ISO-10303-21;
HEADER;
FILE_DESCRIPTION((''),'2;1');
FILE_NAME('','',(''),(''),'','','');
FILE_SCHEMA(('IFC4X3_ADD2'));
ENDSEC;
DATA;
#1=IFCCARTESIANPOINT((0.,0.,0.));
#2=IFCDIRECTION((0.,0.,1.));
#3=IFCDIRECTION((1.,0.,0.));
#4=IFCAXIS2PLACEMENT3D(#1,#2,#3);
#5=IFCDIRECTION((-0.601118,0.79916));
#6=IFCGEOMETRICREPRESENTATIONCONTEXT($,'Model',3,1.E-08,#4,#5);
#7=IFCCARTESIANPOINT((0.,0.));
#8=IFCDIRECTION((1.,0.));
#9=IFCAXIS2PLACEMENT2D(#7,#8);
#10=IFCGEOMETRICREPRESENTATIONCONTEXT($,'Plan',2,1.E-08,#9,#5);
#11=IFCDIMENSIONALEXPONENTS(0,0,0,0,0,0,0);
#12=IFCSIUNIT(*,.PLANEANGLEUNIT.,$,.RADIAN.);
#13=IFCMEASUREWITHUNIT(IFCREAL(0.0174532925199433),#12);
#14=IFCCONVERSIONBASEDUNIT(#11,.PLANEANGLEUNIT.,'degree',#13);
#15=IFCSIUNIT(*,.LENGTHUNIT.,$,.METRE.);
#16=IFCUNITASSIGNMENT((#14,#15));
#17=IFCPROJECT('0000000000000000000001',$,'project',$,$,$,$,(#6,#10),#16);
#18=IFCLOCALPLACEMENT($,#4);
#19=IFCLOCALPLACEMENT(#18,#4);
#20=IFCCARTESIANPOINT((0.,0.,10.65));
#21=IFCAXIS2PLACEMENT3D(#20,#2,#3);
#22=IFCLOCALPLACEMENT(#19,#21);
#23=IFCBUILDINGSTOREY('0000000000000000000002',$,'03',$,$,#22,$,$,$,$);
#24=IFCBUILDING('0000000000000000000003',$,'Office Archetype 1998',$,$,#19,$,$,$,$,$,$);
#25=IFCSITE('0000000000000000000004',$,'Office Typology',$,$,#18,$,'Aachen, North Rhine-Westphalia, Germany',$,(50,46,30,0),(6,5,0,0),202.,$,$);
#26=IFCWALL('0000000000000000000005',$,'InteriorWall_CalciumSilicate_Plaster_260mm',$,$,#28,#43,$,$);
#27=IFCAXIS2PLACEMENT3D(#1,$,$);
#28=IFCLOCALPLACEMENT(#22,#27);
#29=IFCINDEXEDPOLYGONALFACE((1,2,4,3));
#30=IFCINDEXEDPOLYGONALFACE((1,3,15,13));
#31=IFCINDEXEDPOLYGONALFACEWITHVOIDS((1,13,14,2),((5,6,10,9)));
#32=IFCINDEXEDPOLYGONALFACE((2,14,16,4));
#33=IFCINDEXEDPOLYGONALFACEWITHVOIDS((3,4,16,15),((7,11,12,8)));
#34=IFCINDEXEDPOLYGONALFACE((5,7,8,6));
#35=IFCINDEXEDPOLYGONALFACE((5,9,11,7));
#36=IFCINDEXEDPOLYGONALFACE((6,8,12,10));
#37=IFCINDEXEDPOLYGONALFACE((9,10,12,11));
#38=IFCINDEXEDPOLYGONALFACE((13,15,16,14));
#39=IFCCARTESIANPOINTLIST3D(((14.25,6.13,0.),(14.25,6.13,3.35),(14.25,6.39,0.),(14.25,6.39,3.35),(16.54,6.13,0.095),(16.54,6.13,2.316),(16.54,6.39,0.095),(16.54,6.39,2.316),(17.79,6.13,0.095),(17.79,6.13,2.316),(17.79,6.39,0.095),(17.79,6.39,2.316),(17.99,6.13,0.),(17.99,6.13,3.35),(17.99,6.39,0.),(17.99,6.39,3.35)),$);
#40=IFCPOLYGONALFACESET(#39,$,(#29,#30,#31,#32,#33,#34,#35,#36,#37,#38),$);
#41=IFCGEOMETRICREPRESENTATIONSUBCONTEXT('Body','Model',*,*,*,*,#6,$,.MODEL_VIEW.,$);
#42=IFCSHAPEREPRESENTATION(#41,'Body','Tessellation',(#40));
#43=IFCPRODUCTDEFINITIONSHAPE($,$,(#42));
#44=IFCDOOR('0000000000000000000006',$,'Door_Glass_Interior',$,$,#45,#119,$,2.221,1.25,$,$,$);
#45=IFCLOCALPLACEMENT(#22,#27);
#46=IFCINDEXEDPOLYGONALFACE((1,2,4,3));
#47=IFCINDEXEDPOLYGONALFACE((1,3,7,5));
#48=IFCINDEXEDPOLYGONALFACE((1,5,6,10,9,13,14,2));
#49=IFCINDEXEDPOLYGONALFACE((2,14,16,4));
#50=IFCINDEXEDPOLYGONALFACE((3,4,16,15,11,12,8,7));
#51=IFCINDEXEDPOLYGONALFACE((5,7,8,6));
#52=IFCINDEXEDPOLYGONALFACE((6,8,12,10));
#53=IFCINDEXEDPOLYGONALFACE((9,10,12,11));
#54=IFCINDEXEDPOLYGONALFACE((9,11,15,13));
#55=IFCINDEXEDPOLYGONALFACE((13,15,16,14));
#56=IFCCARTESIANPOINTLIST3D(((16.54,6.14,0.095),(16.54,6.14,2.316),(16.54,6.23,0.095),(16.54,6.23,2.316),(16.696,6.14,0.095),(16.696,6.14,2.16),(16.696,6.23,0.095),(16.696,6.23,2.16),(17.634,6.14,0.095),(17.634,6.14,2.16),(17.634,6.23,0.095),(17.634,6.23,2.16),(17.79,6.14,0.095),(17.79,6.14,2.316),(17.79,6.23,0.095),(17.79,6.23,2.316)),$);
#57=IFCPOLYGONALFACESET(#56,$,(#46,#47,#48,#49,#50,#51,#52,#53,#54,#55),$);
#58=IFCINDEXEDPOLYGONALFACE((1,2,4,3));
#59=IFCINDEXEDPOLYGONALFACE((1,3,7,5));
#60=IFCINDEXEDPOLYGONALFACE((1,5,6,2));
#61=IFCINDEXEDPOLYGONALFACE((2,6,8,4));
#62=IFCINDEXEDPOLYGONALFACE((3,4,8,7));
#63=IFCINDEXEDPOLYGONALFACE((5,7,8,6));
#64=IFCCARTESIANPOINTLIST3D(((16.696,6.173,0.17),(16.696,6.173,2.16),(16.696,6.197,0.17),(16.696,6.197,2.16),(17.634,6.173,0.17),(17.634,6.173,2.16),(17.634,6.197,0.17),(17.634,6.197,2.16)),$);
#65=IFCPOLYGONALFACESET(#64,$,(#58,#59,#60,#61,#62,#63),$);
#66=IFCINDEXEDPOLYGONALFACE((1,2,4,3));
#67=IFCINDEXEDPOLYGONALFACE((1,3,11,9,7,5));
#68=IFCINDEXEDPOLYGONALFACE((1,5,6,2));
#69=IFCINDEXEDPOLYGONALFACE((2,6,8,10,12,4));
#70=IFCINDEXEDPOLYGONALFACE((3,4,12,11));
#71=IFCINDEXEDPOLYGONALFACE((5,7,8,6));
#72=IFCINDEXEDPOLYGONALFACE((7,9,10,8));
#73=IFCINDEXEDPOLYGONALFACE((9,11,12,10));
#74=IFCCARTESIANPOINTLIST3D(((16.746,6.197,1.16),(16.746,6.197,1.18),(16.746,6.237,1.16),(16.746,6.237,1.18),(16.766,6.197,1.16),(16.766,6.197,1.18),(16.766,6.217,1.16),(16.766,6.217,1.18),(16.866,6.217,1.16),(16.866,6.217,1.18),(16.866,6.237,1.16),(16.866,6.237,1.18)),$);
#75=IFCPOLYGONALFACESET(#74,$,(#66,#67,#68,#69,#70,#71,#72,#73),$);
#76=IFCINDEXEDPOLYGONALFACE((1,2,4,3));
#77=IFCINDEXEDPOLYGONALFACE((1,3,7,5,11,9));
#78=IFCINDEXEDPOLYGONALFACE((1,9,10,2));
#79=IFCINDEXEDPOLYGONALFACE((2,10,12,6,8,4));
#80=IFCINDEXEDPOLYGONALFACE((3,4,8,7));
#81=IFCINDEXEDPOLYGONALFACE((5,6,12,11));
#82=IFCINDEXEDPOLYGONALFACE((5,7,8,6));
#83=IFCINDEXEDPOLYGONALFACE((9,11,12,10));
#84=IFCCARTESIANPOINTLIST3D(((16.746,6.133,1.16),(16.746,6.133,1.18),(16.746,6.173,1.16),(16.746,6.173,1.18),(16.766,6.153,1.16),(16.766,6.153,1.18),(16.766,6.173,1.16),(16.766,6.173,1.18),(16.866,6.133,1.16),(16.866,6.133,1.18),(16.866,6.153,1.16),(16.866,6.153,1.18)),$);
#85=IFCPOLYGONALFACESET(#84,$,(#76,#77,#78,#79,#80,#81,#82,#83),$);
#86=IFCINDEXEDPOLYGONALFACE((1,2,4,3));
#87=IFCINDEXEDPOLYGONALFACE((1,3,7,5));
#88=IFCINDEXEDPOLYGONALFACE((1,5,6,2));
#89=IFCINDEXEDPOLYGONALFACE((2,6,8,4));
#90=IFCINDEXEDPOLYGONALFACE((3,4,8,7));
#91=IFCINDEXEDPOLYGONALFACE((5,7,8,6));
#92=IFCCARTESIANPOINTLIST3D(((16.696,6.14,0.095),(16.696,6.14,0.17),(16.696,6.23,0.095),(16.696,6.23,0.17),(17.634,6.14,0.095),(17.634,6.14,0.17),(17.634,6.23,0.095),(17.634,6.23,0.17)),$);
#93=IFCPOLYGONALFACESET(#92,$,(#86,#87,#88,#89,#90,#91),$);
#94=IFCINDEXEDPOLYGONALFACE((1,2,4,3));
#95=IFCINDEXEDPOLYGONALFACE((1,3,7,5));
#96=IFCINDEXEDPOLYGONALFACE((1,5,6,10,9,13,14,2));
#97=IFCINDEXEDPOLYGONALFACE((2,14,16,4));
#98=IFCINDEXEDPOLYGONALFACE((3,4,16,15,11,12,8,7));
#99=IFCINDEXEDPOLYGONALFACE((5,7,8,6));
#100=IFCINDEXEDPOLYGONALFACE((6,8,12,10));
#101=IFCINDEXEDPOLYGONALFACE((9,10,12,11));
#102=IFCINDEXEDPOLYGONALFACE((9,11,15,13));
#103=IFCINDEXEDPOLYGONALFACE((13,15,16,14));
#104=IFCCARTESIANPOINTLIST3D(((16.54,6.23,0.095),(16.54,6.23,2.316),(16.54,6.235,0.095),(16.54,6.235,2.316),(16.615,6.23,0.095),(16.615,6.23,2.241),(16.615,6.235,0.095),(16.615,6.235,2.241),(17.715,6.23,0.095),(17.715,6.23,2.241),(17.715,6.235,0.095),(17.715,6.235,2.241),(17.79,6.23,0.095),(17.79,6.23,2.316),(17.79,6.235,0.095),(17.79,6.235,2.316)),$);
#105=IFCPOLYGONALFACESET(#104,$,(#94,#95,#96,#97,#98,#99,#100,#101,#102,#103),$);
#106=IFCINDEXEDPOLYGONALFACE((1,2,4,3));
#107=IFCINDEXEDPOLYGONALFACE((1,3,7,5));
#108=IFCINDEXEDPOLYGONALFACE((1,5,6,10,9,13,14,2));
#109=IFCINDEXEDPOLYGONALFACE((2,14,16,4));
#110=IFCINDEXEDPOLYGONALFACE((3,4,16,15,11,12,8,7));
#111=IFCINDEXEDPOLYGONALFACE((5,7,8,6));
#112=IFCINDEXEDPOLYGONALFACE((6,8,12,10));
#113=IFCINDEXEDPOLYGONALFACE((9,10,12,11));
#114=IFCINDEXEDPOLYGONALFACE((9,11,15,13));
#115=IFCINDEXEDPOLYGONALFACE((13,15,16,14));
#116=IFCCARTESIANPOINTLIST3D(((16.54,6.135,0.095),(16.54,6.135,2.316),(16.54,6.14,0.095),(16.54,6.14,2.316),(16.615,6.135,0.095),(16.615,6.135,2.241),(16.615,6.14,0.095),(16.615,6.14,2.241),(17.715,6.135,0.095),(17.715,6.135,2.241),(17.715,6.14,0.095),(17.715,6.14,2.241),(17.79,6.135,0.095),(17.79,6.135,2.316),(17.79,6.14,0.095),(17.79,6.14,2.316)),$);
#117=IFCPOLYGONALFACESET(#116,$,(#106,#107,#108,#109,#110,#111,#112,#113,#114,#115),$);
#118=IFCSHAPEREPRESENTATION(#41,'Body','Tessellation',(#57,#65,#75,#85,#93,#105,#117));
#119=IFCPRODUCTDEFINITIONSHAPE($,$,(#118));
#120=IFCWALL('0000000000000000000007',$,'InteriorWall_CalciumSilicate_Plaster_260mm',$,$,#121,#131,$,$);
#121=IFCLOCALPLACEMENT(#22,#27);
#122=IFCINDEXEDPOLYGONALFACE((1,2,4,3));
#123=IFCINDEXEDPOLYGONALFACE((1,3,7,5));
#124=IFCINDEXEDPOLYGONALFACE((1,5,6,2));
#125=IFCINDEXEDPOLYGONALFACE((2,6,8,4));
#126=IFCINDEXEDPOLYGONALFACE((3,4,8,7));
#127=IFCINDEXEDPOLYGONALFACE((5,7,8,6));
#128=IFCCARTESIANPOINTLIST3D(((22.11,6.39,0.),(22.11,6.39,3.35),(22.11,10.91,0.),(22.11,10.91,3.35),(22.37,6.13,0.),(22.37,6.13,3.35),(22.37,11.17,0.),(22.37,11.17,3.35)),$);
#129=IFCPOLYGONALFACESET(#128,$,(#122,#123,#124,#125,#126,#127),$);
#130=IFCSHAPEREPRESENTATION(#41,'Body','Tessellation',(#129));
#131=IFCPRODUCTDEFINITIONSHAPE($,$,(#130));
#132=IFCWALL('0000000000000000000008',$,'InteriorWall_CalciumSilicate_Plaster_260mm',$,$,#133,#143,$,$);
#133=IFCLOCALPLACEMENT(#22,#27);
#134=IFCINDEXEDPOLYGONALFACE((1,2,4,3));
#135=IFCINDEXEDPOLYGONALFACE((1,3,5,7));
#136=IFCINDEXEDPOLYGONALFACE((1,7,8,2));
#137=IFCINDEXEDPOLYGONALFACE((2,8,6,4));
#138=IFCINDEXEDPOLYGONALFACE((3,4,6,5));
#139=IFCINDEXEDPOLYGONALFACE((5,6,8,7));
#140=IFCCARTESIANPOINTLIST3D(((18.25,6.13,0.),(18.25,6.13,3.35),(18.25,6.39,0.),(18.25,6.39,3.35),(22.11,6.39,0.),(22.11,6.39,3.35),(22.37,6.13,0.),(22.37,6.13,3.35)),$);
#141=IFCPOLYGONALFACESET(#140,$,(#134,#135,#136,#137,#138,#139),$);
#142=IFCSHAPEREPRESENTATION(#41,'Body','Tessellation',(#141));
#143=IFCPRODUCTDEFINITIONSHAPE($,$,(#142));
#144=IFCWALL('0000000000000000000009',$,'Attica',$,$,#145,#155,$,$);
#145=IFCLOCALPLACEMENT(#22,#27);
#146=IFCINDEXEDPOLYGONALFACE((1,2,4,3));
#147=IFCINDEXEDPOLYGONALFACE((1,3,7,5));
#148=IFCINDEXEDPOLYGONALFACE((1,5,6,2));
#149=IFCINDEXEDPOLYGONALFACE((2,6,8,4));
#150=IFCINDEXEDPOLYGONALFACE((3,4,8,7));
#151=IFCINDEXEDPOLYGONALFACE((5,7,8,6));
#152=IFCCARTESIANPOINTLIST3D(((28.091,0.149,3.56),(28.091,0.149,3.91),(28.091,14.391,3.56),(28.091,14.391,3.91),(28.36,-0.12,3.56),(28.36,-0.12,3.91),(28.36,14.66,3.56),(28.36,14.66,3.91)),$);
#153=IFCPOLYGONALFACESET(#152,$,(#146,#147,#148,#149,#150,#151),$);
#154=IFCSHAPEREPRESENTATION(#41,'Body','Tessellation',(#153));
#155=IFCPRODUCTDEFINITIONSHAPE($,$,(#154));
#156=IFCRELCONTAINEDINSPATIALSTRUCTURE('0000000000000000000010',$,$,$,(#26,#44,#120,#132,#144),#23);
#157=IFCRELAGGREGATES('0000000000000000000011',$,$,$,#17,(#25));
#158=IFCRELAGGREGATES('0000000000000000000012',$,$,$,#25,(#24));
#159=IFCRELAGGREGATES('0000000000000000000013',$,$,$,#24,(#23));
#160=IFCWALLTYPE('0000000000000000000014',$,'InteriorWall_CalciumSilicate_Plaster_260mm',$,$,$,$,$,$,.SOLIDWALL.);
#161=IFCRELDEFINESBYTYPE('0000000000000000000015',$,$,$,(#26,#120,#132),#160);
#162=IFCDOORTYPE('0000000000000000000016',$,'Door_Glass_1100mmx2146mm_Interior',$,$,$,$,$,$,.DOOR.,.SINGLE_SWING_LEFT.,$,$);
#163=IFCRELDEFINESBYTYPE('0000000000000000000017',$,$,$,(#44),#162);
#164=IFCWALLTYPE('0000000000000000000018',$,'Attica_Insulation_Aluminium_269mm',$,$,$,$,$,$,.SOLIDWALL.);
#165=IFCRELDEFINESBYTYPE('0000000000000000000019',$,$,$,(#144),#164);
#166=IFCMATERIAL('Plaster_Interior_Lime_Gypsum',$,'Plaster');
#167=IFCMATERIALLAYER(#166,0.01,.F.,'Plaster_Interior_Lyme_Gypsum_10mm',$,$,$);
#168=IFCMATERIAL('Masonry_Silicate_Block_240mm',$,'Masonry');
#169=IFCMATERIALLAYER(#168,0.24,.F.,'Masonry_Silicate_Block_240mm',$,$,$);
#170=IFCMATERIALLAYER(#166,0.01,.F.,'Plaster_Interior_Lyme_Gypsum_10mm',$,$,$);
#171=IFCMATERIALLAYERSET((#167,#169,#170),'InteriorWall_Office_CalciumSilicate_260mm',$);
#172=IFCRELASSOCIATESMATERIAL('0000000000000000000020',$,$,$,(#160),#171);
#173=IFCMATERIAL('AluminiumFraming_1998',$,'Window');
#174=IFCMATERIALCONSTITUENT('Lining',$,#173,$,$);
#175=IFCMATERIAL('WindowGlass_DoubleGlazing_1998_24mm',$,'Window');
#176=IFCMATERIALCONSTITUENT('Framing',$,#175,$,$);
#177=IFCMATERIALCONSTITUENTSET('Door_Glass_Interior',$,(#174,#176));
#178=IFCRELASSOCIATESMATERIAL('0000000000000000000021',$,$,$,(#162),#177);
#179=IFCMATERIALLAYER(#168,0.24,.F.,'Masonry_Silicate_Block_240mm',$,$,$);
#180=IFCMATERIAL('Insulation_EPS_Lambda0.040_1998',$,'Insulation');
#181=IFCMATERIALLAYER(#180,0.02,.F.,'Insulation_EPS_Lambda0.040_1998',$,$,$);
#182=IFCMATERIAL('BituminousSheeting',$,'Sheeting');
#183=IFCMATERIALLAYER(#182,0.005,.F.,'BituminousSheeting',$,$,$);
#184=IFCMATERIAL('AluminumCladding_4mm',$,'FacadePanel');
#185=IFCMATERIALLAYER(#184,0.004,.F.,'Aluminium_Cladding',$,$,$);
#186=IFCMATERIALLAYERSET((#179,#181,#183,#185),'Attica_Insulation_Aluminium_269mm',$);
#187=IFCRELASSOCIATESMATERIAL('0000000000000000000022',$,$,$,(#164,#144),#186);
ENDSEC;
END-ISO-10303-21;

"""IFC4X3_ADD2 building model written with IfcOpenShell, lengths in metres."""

from ifc_helpers import new_model, entity, si_unit, converted_unit, direction, frame, origin_with_axes, origin_2d_with_axis, place, context, subcontext, project, spatial, line, indexed_curve, outline, extrude, source, transform, mapped, material, layer, layer_set, layer_usage, constituent, constituent_set, type_object, type_shapes, element, fill, save


model = new_model("IFC4X3_ADD2")

# Units and contexts
model_context = context("Model", 3, precision=1e-08, world=origin_with_axes(), true_north=direction((-0.601118, 0.79916)))
plan_context = context("Plan", 2, precision=1e-08, world=origin_2d_with_axis(), true_north=direction((-0.601118, 0.79916)))
body_context = subcontext(model_context, "Body", "Model", "MODEL_VIEW")
ifc_project = project(units=[converted_unit("PLANEANGLEUNIT", "degree", entity("IfcReal", 0.0174532925199433), si_unit("PLANEANGLEUNIT", "RADIAN"), dimensions=[0, 0, 0, 0, 0, 0, 0]), si_unit("LENGTHUNIT", "METRE")], contexts=[model_context, plan_context])

# Site, building, storey
site_placement = place(None, origin_with_axes())
site = spatial("IfcSite", under=ifc_project, at=site_placement, Name="Office Typology", LongName="Aachen, North Rhine-Westphalia, Germany", RefLatitude=(50, 46, 30, 0), RefLongitude=(6, 5, 0, 0), RefElevation=202.0)
building_placement = place(site_placement, origin_with_axes())
building = spatial("IfcBuilding", under=site, at=building_placement, Name="Office Archetype 1998")
storey_placement = place(building_placement, frame((0.0, 0.0, 10.65), z_axis=(0.0, 0.0, 1.0), x_axis=(1.0, 0.0, 0.0)))
storey = spatial("IfcBuildingStorey", under=building, at=storey_placement, Name="03")

# Wall, opening, door
ifc_material_1 = material(Name="Plaster_Interior_Lime_Gypsum", Category="Plaster")
ifc_layer_1 = layer(ifc_material_1, 0.01, ventilated=False, Name="Plaster_Interior_Lyme_Gypsum_10mm")
ifc_material_2 = material(Name="Masonry_Silicate_Block_240mm", Category="Masonry")
ifc_layer_2 = layer(ifc_material_2, 0.24, ventilated=False, Name="Masonry_Silicate_Block_240mm")
ifc_layer_3 = layer(ifc_material_1, 0.01, ventilated=False, Name="Plaster_Interior_Lyme_Gypsum_10mm")
ifc_layer_set_1 = layer_set([ifc_layer_1, ifc_layer_2, ifc_layer_3], Name="InteriorWall_Office_CalciumSilicate_260mm")
wall_type_1 = type_object("IfcWallType", Name="InteriorWall_CalciumSilicate_Plaster_260mm", PredefinedType="SOLIDWALL", material=ifc_layer_set_1)
wall_1_placement = place(storey_placement, frame((18.25, 6.39, 0.0), z_axis=(0.0, 0.0, 1.0), x_axis=(-1.0, 0.0, 0.0)))
wall_1 = element("IfcWall", 1, at=wall_1_placement, inside=storey, type_object=wall_type_1, Name="InteriorWall_CalciumSilicate_Plaster_260mm", context=body_context, shape_type="SweptSolid", body=[
    extrude(outline(indexed_curve([(0.26, 0.0), (0.26, 0.26), (4.0, 0.26), (4.0, 0.0), (0.26, 0.0)])), origin_with_axes(), (0.0, 0.0, 1.0), 3.35),
])
shared_shape_1 = source(origin_with_axes(), body_context, "Body", "SweptSolid", [
    extrude(outline(indexed_curve([(0.0, 2.221), (1.25, 2.221), (1.25, 0.0), (0.0, 0.0), (0.0, 2.221)])), frame((0.0, -0.16, 0.0), z_axis=(0.0, -1.0, 0.0), x_axis=(1.0, 0.0, 0.0)), (0.0, 0.0, -1.0), 0.26),
])
opening_1_placement = place(wall_1_placement, frame((0.46, 0.16, 0.095), z_axis=(0.0, 0.0, 1.0), x_axis=(1.0, 0.0, 0.0)))
opening_1 = element("IfcOpeningElement", 2, at=opening_1_placement, cuts=wall_1, PredefinedType="OPENING", context=body_context, shape_type="MappedRepresentation", body=[
    mapped(shared_shape_1, transform((0.0, 0.0, 0.0), x_axis=(1.0, 0.0, 0.0), y_axis=(0.0, 1.0, 0.0), z_axis=(0.0, 0.0, 1.0), scale=1.0)),
])
ifc_material_3 = material(Name="AluminiumFraming_1998", Category="Window")
ifc_constituent_1 = constituent(ifc_material_3, Name="Lining")
ifc_material_4 = material(Name="WindowGlass_DoubleGlazing_1998_24mm", Category="Window")
ifc_constituent_2 = constituent(ifc_material_4, Name="Framing")
ifc_constituent_set_1 = constituent_set(constituents=[ifc_constituent_1, ifc_constituent_2], Name="Door_Glass_Interior")
door_type = type_object("IfcDoorType", Name="Door_Glass_1100mmx2146mm_Interior", OperationType="SINGLE_SWING_LEFT", PredefinedType="DOOR", material=ifc_constituent_set_1)
shared_shape_2 = source(origin_with_axes(), body_context, "Body", "SweptSolid", [
    extrude(outline(indexed_curve([(0.0, 0.0), (0.0, 2.221), (1.25, 2.221), (1.25, 0.0), (1.094, 0.0), (1.094, 2.065), (0.156, 2.065), (0.156, 0.0)], segments=[line(1, 2, 3, 4, 5, 6, 7, 8, 1)])), frame((0.0, 0.0, 0.0), z_axis=(0.0, -1.0, 0.0), x_axis=(1.0, 0.0, 0.0)), (0.0, 0.0, -1.0), 0.09),
    extrude(outline(indexed_curve([(0.0, 0.0), (0.938, 0.0), (0.938, 0.024), (0.0, 0.024)], segments=[line(1, 2, 3, 4, 1)])), frame((0.156, 0.033, 0.075), z_axis=(0.0, 0.0, 1.0), x_axis=(1.0, 0.0, 0.0)), (0.0, 0.0, 1.0), 1.99),
    extrude(outline(indexed_curve([(0.0, 0.0), (0.0, -0.04), (-0.12, -0.04), (-0.12, -0.02), (-0.02, -0.02), (-0.02, 0.0)], segments=[line(1, 2, 3, 4, 5, 6, 1)])), frame((1.044, 0.033, 1.065), z_axis=(0.0, 0.0, 1.0), x_axis=(1.0, 0.0, 0.0)), (0.0, 0.0, 1.0), 0.02),
    extrude(outline(indexed_curve([(0.0, 0.0), (0.0, 0.04), (-0.12, 0.04), (-0.12, 0.02), (-0.02, 0.02), (-0.02, 0.0)], segments=[line(1, 2, 3, 4, 5, 6, 1)])), frame((1.044, 0.057, 1.065), z_axis=(0.0, 0.0, 1.0), x_axis=(1.0, 0.0, 0.0)), (0.0, 0.0, 1.0), 0.02),
    extrude(outline(indexed_curve([(0.0, 0.0), (0.938, 0.0), (0.938, 0.09), (0.0, 0.09)], segments=[line(1, 2, 3, 4, 1)])), frame((0.156, 0.0, 0.0), z_axis=(0.0, 0.0, 1.0), x_axis=(1.0, 0.0, 0.0)), (0.0, 0.0, 1.0), 0.075),
    extrude(outline(indexed_curve([(0.0, 0.0), (0.0, 2.221), (1.25, 2.221), (1.25, 0.0), (1.175, 0.0), (1.175, 2.146), (0.075, 2.146), (0.075, 0.0)], segments=[line(1, 2, 3, 4, 5, 6, 7, 8, 1)])), frame((0.0, -0.005, 0.0), z_axis=(0.0, -1.0, 0.0), x_axis=(1.0, 0.0, 0.0)), (0.0, 0.0, -1.0), 0.005),
    extrude(outline(indexed_curve([(0.0, 0.0), (0.0, 2.221), (1.25, 2.221), (1.25, 0.0), (1.175, 0.0), (1.175, 2.146), (0.075, 2.146), (0.075, 0.0)], segments=[line(1, 2, 3, 4, 5, 6, 7, 8, 1)])), frame((0.0, 0.09, 0.0), z_axis=(0.0, -1.0, 0.0), x_axis=(1.0, 0.0, 0.0)), (0.0, 0.0, -1.0), 0.005),
])
type_shapes(door_type, [shared_shape_2])
door_placement = place(opening_1_placement, origin_with_axes())
door = element("IfcDoor", 3, at=door_placement, inside=storey, type_object=door_type, Name="Door_Glass_Interior", OverallHeight=2.221, OverallWidth=1.25, context=body_context, shape_type="MappedRepresentation", body=[
    mapped(shared_shape_2, transform((0.0, 0.0, 0.0), x_axis=(1.0, 0.0, 0.0), y_axis=(0.0, 1.0, 0.0), z_axis=(0.0, 0.0, 1.0), scale=1.0)),
])
fill(opening_1, door)

# Walls
wall_2_placement = place(storey_placement, frame((22.37, 6.13, 0.0), z_axis=(0.0, 0.0, 1.0), x_axis=(0.0, 1.0, 0.0)))
element("IfcWall", 4, at=wall_2_placement, inside=storey, type_object=wall_type_1, Name="InteriorWall_CalciumSilicate_Plaster_260mm", context=body_context, shape_type="SweptSolid", body=[
    extrude(outline(indexed_curve([(0.0, 0.0), (0.26, 0.26), (4.78, 0.26), (5.04, 0.0)], segments=[line(1, 2, 3, 4, 1)])), origin_with_axes(), (0.0, 0.0, 1.0), 3.35),
])
wall_3_placement = place(storey_placement, frame((18.25, 6.13, 0.0), z_axis=(0.0, 0.0, 1.0), x_axis=(1.0, 0.0, 0.0)))
element("IfcWall", 5, at=wall_3_placement, inside=storey, type_object=wall_type_1, Name="InteriorWall_CalciumSilicate_Plaster_260mm", context=body_context, shape_type="SweptSolid", body=[
    extrude(outline(indexed_curve([(0.0, 0.0), (0.0, 0.26), (3.86, 0.26), (4.12, 0.0)], segments=[line(1, 2, 3, 4, 1)])), origin_with_axes(), (0.0, 0.0, 1.0), 3.35),
])

# Wall
ifc_layer_4 = layer(ifc_material_2, 0.24, ventilated=False, Name="Masonry_Silicate_Block_240mm")
ifc_material_5 = material(Name="Insulation_EPS_Lambda0.040_1998", Category="Insulation")
ifc_layer_5 = layer(ifc_material_5, 0.02, ventilated=False, Name="Insulation_EPS_Lambda0.040_1998")
ifc_material_6 = material(Name="BituminousSheeting", Category="Sheeting")
ifc_layer_6 = layer(ifc_material_6, 0.005, ventilated=False, Name="BituminousSheeting")
ifc_material_7 = material(Name="AluminumCladding_4mm", Category="FacadePanel")
ifc_layer_7 = layer(ifc_material_7, 0.004, ventilated=False, Name="Aluminium_Cladding")
ifc_layer_set_2 = layer_set([ifc_layer_4, ifc_layer_5, ifc_layer_6, ifc_layer_7], Name="Attica_Insulation_Aluminium_269mm")
ifc_layer_usage_1 = layer_usage(ifc_layer_set_2, "AXIS2", "POSITIVE", 0.0)
wall_type_2 = type_object("IfcWallType", Name="Attica_Insulation_Aluminium_269mm", PredefinedType="SOLIDWALL", material=ifc_layer_set_2)
wall_4_placement = place(storey_placement, frame((28.36, -0.12, 3.56), z_axis=(0.0, 0.0, 1.0), x_axis=(0.0, 1.0, 0.0)))
element("IfcWall", 6, at=wall_4_placement, inside=storey, type_object=wall_type_2, material=ifc_layer_usage_1, Name="Attica", context=body_context, shape_type="SweptSolid", body=[
    extrude(outline(indexed_curve([(0.0, 0.0), (0.269, 0.269), (14.511, 0.269), (14.78, 0.0)], segments=[line(1, 2, 3, 4, 1)])), origin_with_axes(), (0.0, 0.0, 1.0), 0.35),
])

save(model, "model.ifc")
